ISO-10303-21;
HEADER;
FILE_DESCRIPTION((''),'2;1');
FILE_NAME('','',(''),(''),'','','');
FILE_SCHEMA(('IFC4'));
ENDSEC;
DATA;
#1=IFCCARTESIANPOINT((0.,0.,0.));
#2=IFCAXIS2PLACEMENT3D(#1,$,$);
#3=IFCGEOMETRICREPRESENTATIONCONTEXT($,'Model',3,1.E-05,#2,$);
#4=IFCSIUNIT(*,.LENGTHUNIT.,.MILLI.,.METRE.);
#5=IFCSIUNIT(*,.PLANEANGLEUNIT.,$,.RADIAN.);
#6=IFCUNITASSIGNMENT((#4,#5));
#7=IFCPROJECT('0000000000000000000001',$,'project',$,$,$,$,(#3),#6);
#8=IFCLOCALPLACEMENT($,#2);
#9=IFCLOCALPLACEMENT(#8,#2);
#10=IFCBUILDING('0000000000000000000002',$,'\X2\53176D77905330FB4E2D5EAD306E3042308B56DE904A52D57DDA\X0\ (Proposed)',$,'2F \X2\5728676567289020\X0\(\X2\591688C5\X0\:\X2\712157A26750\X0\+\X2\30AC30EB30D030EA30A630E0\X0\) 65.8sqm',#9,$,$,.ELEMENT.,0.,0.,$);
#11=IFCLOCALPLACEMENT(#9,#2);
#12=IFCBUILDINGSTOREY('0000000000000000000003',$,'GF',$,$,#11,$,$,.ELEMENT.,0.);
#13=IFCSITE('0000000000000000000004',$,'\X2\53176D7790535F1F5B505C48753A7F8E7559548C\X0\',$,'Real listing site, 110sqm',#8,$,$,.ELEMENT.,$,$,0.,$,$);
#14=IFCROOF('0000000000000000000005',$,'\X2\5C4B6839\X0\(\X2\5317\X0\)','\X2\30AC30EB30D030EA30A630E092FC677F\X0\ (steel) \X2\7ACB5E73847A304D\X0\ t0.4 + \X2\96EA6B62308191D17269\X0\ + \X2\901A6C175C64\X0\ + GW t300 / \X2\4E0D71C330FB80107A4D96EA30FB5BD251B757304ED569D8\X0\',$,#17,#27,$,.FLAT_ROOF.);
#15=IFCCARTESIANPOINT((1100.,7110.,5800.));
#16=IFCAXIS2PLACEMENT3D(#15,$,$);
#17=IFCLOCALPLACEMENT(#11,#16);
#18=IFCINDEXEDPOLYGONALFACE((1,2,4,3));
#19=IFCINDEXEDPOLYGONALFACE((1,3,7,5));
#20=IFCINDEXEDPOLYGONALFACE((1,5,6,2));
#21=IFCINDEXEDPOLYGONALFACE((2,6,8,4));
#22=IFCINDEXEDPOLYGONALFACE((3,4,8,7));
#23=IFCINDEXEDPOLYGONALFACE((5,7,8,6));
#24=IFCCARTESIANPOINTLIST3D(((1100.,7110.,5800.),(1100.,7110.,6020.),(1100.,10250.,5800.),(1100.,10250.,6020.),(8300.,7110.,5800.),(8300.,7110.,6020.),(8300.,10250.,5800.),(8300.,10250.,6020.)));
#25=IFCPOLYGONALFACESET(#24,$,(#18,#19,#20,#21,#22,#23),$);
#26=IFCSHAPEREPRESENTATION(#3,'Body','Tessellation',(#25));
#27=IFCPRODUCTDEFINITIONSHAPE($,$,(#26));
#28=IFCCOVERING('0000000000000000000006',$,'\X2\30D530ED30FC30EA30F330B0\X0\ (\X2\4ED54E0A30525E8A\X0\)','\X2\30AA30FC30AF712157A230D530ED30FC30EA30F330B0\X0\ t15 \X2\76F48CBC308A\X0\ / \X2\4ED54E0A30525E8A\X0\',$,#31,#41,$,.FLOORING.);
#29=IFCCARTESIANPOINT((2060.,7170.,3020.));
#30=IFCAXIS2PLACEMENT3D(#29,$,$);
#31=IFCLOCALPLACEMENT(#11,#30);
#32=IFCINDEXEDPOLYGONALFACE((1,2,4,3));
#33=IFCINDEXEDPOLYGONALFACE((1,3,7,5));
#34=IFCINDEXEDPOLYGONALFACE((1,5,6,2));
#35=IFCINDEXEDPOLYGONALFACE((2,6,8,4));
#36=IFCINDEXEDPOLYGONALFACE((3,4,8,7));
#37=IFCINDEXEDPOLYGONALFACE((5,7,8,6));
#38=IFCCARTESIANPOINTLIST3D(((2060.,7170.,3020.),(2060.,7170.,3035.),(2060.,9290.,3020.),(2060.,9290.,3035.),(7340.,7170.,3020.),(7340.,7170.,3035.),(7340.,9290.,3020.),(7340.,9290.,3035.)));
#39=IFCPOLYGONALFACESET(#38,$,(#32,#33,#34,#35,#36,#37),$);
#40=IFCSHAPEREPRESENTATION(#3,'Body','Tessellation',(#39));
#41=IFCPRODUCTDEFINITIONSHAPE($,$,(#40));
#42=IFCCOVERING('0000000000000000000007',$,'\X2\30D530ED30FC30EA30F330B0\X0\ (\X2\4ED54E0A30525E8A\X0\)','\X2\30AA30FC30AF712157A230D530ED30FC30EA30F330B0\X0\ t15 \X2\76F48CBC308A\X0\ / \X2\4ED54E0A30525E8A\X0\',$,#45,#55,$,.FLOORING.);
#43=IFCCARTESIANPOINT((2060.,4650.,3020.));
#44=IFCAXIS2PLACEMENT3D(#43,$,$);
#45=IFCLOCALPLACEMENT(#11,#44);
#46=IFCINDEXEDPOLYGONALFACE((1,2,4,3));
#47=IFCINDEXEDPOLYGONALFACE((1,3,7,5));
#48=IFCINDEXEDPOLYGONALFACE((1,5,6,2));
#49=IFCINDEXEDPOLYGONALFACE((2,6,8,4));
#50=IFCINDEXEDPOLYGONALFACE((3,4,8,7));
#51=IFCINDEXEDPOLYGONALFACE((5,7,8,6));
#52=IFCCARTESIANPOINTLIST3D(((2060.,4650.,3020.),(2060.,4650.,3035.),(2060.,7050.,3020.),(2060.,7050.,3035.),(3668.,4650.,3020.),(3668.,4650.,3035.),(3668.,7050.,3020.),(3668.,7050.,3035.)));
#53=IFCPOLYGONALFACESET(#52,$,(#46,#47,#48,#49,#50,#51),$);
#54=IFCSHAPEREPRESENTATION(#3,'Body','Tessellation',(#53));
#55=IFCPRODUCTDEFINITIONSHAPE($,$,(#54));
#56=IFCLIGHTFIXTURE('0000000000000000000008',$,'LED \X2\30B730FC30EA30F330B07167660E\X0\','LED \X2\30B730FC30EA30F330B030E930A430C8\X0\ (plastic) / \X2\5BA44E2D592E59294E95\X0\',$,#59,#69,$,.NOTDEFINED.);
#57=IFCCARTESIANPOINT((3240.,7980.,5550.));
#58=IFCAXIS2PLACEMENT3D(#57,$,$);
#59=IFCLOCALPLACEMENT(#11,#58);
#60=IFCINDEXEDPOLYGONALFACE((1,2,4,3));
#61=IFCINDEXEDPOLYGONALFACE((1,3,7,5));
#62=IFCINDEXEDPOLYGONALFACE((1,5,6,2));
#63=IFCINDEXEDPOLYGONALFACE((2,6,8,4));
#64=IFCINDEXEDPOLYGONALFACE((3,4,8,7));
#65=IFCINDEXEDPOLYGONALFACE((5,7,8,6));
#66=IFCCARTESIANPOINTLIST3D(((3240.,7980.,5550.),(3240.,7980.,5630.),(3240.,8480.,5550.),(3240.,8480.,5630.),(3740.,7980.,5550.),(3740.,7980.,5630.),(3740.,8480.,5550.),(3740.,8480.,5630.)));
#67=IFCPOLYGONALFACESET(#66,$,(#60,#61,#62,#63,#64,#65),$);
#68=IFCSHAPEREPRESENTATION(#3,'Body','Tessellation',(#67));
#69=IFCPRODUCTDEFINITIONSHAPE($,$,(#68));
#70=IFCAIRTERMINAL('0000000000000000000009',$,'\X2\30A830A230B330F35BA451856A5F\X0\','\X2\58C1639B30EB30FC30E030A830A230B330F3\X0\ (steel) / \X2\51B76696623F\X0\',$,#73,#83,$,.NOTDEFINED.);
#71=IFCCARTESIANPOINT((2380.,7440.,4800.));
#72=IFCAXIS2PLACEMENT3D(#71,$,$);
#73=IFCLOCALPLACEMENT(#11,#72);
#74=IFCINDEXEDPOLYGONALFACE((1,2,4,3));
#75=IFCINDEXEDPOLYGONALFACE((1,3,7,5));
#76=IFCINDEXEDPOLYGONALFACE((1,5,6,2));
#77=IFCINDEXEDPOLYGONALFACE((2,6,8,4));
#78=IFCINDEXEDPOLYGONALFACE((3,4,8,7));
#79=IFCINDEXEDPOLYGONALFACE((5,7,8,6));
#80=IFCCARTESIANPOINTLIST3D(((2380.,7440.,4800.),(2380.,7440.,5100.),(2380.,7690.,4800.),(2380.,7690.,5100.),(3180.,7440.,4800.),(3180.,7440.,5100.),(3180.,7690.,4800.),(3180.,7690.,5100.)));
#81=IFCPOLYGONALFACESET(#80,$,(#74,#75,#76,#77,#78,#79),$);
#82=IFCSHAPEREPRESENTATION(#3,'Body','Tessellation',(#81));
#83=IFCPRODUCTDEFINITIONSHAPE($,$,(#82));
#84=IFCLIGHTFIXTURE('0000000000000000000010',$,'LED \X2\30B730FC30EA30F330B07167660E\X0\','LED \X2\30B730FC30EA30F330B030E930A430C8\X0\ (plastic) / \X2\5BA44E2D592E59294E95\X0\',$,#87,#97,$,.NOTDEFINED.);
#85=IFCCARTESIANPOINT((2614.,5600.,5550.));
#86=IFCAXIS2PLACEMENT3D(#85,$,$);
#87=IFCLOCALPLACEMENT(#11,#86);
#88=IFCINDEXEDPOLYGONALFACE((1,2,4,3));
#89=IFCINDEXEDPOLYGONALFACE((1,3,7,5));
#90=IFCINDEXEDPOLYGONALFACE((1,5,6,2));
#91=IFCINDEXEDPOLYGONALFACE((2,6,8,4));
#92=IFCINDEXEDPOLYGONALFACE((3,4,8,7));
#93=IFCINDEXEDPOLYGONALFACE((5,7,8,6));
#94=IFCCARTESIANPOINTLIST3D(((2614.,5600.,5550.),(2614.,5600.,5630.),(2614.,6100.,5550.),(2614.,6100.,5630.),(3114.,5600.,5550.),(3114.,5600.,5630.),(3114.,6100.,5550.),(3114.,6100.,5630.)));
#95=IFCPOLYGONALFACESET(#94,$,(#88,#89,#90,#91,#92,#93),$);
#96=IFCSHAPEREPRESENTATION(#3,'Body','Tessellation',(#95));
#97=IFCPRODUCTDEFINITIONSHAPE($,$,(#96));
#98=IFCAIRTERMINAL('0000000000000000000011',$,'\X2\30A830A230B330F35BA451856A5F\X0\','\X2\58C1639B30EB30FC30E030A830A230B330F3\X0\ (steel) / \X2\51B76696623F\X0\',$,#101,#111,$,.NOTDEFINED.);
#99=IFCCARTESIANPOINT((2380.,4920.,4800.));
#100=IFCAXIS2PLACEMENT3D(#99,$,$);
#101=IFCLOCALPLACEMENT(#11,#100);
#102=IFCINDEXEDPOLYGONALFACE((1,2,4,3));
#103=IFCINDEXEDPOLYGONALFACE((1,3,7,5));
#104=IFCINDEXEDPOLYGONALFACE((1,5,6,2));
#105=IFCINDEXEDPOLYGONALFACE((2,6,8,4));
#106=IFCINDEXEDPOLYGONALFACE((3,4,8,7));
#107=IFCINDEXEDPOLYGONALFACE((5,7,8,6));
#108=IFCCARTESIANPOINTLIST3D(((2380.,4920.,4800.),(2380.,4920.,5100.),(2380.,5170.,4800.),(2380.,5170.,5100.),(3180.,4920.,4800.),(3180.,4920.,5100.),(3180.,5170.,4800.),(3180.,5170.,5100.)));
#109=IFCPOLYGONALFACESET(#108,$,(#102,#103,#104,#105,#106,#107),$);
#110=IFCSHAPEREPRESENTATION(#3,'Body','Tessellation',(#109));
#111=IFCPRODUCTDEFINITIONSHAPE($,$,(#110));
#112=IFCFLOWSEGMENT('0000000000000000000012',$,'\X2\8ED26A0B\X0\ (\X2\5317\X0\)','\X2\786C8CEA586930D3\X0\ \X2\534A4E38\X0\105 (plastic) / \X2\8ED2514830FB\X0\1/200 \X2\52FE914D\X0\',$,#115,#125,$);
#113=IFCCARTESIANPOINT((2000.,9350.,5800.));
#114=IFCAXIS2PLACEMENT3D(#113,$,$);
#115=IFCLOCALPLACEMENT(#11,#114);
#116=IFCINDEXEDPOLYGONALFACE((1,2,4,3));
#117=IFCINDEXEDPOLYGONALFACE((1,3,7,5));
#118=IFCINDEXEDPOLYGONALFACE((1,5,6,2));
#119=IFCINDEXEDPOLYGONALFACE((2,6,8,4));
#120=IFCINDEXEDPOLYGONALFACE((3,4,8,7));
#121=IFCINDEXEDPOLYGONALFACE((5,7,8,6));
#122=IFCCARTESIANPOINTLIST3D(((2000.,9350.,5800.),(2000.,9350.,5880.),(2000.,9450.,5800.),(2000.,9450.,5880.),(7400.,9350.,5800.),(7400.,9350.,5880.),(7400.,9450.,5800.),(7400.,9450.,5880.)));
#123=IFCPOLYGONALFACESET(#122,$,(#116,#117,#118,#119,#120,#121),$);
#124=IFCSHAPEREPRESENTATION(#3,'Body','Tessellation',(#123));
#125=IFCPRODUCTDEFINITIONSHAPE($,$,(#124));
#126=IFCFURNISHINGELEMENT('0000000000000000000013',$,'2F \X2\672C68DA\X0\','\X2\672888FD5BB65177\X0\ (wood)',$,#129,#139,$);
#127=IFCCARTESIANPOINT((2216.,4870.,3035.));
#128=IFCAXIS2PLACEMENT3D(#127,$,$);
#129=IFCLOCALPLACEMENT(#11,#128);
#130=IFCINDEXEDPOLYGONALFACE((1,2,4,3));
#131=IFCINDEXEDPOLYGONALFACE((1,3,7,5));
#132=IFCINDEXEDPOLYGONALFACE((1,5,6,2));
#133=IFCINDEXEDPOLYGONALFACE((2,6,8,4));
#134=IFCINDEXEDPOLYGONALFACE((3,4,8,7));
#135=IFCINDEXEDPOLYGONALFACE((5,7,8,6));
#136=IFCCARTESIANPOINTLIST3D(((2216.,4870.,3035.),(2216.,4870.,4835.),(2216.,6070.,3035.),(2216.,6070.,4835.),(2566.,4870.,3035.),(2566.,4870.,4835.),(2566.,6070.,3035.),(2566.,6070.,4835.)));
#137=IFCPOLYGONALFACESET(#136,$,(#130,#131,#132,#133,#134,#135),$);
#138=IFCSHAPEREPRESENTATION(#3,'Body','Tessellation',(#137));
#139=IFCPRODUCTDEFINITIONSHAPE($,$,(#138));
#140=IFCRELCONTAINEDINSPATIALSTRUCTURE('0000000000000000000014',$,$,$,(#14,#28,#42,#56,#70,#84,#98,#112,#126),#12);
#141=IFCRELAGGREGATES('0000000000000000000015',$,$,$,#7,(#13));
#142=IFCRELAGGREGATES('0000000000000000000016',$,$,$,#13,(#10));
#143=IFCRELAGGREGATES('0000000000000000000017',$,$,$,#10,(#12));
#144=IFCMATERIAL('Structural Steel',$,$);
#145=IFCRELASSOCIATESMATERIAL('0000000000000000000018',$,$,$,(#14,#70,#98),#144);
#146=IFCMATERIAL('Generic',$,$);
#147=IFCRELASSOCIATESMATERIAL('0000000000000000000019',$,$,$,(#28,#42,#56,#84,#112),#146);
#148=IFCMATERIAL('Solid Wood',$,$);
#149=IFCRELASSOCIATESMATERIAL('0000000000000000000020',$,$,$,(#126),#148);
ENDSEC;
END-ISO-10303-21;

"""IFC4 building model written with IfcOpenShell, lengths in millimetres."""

from ifc_helpers import new_model, si_unit, frame, frame_2d, origin, place, context, project, spatial, rectangle, extrude, material, element, save


model = new_model("IFC4")

# Units and contexts
model_context = context("Model", 3, precision=1e-05, world=origin())
ifc_project = project(units=[si_unit("LENGTHUNIT", "METRE", prefix="MILLI"), si_unit("PLANEANGLEUNIT", "RADIAN")], contexts=[model_context])

# Site, building, storey
site_placement = place(None, origin())
site = spatial("IfcSite", under=ifc_project, at=site_placement, Name="北海道弟子屈町美留和", ObjectType="Real listing site, 110sqm", CompositionType="ELEMENT", RefElevation=0.0)
building_placement = place(site_placement, origin())
building = spatial("IfcBuilding", under=site, at=building_placement, Name="北海道・中庭のある回遊動線 (Proposed)", ObjectType="2F 在来木造(外装:無垢材+ガルバリウム) 65.8sqm", CompositionType="ELEMENT", ElevationOfRefHeight=0.0, ElevationOfTerrain=0.0)
storey_placement = place(building_placement, origin())
storey = spatial("IfcBuildingStorey", under=building, at=storey_placement, Name="GF", CompositionType="ELEMENT", Elevation=0.0)

# Shared definitions
ifc_material_1 = material(Name="Solid Wood")

# Roof
ifc_material_2 = material(Name="Structural Steel")
for number, where, name in (
    (1, (1100.0, 7110.0, 5800.0), "屋根(北)"),
):
    element("IfcRoof", number, at=place(storey_placement, frame(where)), inside=storey, material=ifc_material_2, Name=name, Description="ガルバリウム鋼板 (steel) 立平葺き t0.4 + 雪止め金物 + 通気層 + GW t300 / 不燃・耐積雪・寒冷地仕様", PredefinedType="FLAT_ROOF", context=model_context, shape_type="SweptSolid", body=[
        extrude(rectangle(XDim=7200.0, YDim=3140.0, at=frame_2d((3600.0, 1570.0))), frame((1100.0, 7110.0, 5800.0)), (0.0, 0.0, 1.0), 220.0),
    ])

# Coverings
ifc_material_3 = material(Name="Generic")
covering_1_placement = place(storey_placement, frame((2060.0, 7170.0, 3020.0)))
element("IfcCovering", 2, at=covering_1_placement, inside=storey, material=ifc_material_3, Name="フローリング (仕上げ床)", Description="オーク無垢フローリング t15 直貼り / 仕上げ床", PredefinedType="FLOORING", context=model_context, shape_type="SweptSolid", body=[
    extrude(rectangle(XDim=5280.0, YDim=2120.0, at=frame_2d((2640.0, 1060.0))), frame((2060.0, 7170.0, 3020.0)), (0.0, 0.0, 1.0), 15.0),
])
covering_2_placement = place(storey_placement, frame((2060.0, 4650.0, 3020.0)))
element("IfcCovering", 3, at=covering_2_placement, inside=storey, material=ifc_material_3, Name="フローリング (仕上げ床)", Description="オーク無垢フローリング t15 直貼り / 仕上げ床", PredefinedType="FLOORING", context=model_context, shape_type="SweptSolid", body=[
    extrude(rectangle(XDim=1608.0, YDim=2400.0, at=frame_2d((804.0, 1200.0))), frame((2060.0, 4650.0, 3020.0)), (0.0, 0.0, 1.0), 15.0),
])

# Light fixture
light_fixture_1_placement = place(storey_placement, frame((3240.0, 7980.0, 5550.0)))
element("IfcLightFixture", 4, at=light_fixture_1_placement, inside=storey, material=ifc_material_3, Name="LED シーリング照明", Description="LED シーリングライト (plastic) / 室中央天井", PredefinedType="NOTDEFINED", context=model_context, shape_type="SweptSolid", body=[
    extrude(rectangle(XDim=500.0, YDim=500.0, at=frame_2d((250.0, 250.0))), frame((3240.0, 7980.0, 5550.0)), (0.0, 0.0, 1.0), 80.0),
])

# Air terminal
air_terminal_1_placement = place(storey_placement, frame((2380.0, 7440.0, 4800.0)))
element("IfcAirTerminal", 5, at=air_terminal_1_placement, inside=storey, material=ifc_material_2, Name="エアコン室内機", Description="壁掛ルームエアコン (steel) / 冷暖房", PredefinedType="NOTDEFINED", context=model_context, shape_type="SweptSolid", body=[
    extrude(rectangle(XDim=800.0, YDim=250.0, at=frame_2d((400.0, 125.0))), frame((2380.0, 7440.0, 4800.0)), (0.0, 0.0, 1.0), 300.0),
])

# Light fixture
light_fixture_2_placement = place(storey_placement, frame((2614.0, 5600.0, 5550.0)))
element("IfcLightFixture", 6, at=light_fixture_2_placement, inside=storey, material=ifc_material_3, Name="LED シーリング照明", Description="LED シーリングライト (plastic) / 室中央天井", PredefinedType="NOTDEFINED", context=model_context, shape_type="SweptSolid", body=[
    extrude(rectangle(XDim=500.0, YDim=500.0, at=frame_2d((250.0, 250.0))), frame((2614.0, 5600.0, 5550.0)), (0.0, 0.0, 1.0), 80.0),
])

# Air terminal
air_terminal_2_placement = place(storey_placement, frame((2380.0, 4920.0, 4800.0)))
element("IfcAirTerminal", 7, at=air_terminal_2_placement, inside=storey, material=ifc_material_2, Name="エアコン室内機", Description="壁掛ルームエアコン (steel) / 冷暖房", PredefinedType="NOTDEFINED", context=model_context, shape_type="SweptSolid", body=[
    extrude(rectangle(XDim=800.0, YDim=250.0, at=frame_2d((400.0, 125.0))), frame((2380.0, 4920.0, 4800.0)), (0.0, 0.0, 1.0), 300.0),
])

# Flow segment
flow_segment_placement = place(storey_placement, frame((2000.0, 9350.0, 5800.0)))
element("IfcFlowSegment", 8, at=flow_segment_placement, inside=storey, material=ifc_material_3, Name="軒樋 (北)", Description="硬質塩ビ 半丸105 (plastic) / 軒先・1/200 勾配", context=model_context, shape_type="SweptSolid", body=[
    extrude(rectangle(XDim=5400.0, YDim=100.0, at=frame_2d((2700.0, 50.0))), frame((2000.0, 9350.0, 5800.0)), (0.0, 0.0, 1.0), 80.0),
])

# Furnishing element
furnishing_placement = place(storey_placement, frame((2216.0, 4870.0, 3035.0)))
element("IfcFurnishingElement", 9, at=furnishing_placement, inside=storey, material=ifc_material_1, Name="2F 本棚", Description="木製家具 (wood)", context=model_context, shape_type="SweptSolid", body=[
    extrude(rectangle(XDim=350.0, YDim=1200.0, at=frame_2d((175.0, 600.0))), frame((2216.0, 4870.0, 3035.0)), (0.0, 0.0, 1.0), 1800.0),
])

save(model, "model.ifc")
